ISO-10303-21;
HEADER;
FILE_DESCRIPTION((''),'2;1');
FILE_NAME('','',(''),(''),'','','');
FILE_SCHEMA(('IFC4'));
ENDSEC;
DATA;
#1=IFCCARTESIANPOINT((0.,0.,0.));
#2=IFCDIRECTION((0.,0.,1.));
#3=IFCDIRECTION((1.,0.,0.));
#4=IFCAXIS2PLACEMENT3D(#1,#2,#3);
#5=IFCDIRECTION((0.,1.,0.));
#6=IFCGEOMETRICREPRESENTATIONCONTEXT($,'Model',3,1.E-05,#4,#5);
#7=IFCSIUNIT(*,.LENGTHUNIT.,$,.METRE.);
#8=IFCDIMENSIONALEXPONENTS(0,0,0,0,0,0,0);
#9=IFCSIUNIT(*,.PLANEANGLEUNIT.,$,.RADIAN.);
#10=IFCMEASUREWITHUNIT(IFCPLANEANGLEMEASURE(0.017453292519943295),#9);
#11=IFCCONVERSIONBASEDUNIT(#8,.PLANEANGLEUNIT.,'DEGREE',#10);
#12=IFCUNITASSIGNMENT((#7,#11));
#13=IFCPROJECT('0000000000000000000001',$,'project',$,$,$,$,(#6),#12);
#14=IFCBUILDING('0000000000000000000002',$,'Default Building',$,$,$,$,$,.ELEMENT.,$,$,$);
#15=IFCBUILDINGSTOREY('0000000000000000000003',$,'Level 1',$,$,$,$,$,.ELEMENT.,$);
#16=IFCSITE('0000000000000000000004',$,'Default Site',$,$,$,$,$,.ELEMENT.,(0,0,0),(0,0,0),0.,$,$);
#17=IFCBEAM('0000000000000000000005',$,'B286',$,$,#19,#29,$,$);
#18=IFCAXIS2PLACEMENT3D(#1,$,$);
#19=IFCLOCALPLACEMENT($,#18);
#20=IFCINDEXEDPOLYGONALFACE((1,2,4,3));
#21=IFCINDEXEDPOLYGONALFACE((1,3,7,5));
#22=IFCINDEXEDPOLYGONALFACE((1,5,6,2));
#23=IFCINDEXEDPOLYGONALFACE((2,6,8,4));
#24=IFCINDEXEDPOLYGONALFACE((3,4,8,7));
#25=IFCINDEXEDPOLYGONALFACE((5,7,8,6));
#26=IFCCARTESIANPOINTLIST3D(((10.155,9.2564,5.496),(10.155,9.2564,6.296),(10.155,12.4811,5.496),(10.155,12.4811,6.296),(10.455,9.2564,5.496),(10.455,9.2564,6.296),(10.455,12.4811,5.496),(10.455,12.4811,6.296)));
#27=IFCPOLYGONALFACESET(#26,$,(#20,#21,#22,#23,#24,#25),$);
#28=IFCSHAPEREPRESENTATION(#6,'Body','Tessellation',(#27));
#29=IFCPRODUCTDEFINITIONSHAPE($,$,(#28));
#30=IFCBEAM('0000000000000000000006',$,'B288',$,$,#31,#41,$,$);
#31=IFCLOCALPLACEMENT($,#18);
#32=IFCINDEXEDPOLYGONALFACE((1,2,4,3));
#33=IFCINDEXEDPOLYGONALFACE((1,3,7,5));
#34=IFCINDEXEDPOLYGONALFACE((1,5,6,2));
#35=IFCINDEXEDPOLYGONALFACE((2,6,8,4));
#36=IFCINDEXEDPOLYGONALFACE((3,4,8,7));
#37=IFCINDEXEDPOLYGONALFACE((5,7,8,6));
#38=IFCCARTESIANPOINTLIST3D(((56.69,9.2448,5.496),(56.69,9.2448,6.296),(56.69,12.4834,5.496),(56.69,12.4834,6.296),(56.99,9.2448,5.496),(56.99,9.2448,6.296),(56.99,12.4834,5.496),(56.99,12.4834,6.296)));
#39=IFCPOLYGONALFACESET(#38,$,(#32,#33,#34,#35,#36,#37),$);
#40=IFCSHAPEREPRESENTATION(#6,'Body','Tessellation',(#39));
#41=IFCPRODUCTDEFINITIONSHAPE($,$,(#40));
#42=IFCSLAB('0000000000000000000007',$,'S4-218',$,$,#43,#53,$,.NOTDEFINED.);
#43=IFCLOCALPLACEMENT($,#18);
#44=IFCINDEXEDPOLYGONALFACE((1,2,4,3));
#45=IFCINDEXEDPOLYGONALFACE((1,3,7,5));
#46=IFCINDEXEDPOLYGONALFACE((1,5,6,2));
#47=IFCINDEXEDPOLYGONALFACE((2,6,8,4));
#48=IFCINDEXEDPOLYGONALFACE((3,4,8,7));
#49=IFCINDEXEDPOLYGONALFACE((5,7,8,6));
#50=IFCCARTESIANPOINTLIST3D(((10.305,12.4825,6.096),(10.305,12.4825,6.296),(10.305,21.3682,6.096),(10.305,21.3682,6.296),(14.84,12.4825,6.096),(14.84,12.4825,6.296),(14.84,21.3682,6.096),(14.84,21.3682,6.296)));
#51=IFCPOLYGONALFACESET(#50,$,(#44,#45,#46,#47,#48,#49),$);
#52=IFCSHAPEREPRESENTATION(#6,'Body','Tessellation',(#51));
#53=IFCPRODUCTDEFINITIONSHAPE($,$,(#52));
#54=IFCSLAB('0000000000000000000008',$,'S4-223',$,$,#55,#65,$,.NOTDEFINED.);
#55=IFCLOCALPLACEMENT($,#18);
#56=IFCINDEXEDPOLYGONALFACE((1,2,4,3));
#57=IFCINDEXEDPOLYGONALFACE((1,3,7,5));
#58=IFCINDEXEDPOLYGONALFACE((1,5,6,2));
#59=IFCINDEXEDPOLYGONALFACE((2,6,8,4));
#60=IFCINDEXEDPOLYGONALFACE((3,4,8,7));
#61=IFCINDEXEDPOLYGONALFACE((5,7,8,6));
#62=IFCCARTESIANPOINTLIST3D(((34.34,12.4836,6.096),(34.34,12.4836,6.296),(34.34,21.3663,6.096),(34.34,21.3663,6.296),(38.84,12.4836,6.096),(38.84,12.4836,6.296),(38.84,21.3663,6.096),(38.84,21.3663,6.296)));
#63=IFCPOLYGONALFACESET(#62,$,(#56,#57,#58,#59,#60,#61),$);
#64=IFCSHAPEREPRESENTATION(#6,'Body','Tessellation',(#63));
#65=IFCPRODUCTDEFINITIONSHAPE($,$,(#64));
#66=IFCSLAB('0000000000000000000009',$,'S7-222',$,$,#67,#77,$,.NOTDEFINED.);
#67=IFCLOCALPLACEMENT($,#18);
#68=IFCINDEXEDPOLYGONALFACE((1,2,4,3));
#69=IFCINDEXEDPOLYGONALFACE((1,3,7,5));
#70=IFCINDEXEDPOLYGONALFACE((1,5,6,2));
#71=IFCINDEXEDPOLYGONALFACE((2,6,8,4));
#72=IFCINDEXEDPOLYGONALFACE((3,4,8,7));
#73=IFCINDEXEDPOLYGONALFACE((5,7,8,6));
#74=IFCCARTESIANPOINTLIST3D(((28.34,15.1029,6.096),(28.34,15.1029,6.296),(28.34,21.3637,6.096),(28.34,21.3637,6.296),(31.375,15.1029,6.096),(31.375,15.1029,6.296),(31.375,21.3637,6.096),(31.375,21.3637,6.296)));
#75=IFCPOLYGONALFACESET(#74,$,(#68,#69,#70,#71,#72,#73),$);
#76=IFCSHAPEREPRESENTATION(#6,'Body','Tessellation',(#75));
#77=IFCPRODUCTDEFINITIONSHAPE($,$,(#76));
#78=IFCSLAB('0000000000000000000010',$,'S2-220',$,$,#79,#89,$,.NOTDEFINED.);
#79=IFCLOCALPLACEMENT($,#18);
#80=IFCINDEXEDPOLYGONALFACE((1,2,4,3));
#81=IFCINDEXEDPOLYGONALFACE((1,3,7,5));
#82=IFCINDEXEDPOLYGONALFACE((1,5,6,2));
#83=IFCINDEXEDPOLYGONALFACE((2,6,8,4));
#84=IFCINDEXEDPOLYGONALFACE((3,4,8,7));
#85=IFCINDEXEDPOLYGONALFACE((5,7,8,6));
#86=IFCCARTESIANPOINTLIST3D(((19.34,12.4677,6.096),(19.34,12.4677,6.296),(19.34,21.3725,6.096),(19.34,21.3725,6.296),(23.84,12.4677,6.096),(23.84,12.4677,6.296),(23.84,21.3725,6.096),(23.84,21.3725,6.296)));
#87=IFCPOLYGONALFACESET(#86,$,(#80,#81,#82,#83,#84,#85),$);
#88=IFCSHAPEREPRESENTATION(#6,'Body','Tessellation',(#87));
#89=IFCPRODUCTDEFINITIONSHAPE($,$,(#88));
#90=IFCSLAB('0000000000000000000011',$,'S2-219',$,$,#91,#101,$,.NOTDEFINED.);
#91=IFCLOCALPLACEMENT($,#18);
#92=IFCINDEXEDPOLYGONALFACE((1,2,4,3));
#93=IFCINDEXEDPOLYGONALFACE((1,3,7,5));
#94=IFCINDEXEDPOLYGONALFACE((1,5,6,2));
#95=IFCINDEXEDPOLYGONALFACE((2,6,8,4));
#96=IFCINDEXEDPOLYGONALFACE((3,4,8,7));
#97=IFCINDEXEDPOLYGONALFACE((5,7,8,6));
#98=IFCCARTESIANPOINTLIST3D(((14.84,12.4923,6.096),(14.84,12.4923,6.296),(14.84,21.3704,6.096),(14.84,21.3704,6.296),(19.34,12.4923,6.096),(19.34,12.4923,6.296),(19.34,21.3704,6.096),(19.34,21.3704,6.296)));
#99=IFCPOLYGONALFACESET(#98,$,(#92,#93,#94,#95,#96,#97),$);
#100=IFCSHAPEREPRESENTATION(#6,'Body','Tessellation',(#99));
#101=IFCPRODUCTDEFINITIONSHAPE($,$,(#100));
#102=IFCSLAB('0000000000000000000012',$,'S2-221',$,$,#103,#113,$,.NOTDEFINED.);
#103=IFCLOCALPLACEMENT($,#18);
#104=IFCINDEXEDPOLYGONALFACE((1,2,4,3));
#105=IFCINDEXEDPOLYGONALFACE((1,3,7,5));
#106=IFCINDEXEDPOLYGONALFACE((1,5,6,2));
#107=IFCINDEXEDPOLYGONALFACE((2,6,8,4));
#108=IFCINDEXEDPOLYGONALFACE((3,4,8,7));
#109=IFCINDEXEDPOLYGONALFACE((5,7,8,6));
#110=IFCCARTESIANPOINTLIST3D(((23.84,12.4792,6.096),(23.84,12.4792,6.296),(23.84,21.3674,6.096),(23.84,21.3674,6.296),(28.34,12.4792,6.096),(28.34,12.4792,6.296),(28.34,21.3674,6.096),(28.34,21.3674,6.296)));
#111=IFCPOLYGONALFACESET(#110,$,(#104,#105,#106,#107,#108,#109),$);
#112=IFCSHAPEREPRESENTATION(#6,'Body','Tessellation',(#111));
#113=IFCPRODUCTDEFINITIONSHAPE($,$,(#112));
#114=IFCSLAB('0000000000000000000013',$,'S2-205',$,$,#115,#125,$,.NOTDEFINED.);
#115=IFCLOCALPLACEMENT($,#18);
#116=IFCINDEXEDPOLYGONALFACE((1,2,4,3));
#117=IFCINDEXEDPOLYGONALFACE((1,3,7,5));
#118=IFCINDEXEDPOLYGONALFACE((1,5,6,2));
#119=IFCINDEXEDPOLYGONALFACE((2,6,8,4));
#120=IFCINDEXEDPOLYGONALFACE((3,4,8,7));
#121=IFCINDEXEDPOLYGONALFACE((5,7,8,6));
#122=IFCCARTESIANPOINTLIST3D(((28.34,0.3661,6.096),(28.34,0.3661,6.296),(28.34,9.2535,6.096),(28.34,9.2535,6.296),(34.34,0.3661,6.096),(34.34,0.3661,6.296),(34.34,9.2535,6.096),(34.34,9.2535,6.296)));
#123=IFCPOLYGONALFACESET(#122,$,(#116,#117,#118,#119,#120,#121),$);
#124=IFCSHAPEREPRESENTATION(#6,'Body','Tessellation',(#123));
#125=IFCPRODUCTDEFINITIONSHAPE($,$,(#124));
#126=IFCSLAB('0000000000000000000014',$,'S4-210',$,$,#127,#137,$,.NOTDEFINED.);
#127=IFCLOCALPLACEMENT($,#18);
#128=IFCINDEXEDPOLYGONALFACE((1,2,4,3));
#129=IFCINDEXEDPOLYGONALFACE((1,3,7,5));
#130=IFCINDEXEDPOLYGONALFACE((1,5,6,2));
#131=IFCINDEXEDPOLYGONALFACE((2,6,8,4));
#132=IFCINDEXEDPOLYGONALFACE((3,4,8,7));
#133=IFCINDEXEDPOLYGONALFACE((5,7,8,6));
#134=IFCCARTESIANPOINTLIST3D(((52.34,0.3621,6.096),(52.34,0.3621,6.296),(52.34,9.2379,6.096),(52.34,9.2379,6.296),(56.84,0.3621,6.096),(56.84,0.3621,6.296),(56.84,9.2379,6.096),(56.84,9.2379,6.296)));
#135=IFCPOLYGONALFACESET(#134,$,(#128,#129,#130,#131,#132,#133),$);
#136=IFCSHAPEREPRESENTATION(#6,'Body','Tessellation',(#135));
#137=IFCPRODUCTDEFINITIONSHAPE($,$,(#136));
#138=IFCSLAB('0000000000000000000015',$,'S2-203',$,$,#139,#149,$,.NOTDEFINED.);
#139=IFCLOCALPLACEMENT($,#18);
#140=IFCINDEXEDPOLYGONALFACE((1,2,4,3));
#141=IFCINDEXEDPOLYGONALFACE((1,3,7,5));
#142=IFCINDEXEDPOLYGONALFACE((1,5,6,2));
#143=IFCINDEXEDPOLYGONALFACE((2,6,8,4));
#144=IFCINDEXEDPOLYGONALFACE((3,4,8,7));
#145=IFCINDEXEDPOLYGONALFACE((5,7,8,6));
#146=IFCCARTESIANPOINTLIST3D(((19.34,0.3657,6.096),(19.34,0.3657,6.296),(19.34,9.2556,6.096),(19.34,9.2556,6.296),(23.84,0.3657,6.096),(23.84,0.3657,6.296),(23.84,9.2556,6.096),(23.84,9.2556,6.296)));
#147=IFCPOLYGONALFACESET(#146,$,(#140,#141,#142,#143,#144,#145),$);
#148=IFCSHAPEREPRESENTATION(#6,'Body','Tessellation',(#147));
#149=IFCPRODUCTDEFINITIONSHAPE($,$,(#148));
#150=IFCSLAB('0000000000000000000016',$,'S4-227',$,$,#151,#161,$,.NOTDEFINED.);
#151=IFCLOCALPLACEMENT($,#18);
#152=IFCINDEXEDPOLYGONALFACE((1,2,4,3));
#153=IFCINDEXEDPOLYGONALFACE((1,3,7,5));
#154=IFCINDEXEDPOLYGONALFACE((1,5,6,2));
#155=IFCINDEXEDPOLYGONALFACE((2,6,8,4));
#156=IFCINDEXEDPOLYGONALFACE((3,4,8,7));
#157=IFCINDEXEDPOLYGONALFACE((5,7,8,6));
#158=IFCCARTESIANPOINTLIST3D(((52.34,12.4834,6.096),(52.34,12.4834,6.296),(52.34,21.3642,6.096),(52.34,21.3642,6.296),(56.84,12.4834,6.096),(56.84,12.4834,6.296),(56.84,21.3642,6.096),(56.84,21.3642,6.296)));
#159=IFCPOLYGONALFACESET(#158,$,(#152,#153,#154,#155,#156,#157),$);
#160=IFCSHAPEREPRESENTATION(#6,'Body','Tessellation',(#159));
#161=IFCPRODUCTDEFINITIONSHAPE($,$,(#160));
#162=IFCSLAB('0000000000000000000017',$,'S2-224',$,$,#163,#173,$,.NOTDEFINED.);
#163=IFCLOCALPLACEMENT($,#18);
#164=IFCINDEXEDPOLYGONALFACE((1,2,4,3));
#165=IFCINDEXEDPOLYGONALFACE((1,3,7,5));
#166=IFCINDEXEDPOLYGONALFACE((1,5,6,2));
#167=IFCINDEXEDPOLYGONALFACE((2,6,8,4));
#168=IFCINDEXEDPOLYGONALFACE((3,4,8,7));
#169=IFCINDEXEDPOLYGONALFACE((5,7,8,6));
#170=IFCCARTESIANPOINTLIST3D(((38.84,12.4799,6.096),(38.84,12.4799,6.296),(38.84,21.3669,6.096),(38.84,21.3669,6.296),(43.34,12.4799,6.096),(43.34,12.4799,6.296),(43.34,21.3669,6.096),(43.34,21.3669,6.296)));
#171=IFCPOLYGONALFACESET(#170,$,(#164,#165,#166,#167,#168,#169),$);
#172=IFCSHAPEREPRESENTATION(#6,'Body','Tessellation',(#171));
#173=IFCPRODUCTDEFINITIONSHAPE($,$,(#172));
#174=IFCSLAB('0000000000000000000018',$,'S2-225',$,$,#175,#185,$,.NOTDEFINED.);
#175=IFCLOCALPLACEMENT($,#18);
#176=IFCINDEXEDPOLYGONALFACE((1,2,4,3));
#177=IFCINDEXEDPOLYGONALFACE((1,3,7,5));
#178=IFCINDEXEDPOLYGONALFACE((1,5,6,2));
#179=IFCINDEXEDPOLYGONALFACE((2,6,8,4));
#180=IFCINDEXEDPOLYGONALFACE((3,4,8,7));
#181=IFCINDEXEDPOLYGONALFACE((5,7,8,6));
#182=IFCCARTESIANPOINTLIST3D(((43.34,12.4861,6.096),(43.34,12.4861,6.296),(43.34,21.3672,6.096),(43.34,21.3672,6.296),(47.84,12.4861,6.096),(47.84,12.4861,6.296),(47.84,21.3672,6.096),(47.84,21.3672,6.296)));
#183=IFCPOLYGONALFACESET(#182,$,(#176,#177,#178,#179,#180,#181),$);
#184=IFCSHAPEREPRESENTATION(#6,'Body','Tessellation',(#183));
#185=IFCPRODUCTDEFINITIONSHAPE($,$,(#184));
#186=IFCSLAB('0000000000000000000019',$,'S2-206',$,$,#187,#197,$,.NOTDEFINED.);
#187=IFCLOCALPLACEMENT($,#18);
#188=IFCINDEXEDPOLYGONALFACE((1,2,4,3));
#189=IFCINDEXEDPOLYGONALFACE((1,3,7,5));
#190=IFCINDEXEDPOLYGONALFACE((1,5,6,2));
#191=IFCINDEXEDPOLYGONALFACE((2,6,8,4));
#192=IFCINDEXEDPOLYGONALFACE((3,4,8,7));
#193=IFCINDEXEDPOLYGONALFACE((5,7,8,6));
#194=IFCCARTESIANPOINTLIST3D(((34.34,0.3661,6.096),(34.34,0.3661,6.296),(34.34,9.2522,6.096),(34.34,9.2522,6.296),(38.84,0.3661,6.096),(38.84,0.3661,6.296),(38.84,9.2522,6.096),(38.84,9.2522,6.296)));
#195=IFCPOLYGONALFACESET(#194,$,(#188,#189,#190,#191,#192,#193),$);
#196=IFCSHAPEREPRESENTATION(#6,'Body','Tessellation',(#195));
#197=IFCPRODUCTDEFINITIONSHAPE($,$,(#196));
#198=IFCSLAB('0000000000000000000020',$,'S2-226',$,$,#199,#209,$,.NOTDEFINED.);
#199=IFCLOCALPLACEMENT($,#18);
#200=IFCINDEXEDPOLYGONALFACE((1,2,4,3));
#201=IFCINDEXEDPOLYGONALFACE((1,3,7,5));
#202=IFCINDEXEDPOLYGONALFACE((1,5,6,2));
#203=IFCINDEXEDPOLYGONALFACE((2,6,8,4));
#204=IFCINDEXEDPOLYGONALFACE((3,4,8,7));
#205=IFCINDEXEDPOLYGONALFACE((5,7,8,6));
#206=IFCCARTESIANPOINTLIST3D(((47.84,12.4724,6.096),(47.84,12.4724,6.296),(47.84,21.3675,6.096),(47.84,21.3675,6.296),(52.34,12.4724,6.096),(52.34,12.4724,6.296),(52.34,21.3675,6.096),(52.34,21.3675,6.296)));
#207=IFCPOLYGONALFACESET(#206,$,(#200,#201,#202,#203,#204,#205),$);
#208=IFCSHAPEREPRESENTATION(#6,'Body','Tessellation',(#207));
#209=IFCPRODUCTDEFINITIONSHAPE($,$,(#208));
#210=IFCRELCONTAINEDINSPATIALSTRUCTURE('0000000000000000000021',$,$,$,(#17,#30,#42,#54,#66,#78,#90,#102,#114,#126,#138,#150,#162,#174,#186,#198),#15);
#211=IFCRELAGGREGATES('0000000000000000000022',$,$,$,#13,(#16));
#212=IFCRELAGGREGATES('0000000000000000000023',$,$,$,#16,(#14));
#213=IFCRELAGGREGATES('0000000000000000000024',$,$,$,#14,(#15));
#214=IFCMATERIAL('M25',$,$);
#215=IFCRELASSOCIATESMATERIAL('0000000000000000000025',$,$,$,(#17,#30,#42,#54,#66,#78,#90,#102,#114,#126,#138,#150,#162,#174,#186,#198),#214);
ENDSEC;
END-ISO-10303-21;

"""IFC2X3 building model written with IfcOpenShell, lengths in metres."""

from ifc_helpers import new_model, entity, si_unit, converted_unit, direction, frame, frame_2d, origin_with_axes, place, context, project, spatial, rectangle, extrude, material, element, save


model = new_model("IFC2X3")

# Units and contexts
model_context = context("Model", 3, precision=1e-05, world=origin_with_axes(), true_north=direction((0.0, 1.0, 0.0)))
ifc_project = project(units=[si_unit("LENGTHUNIT", "METRE"), converted_unit("PLANEANGLEUNIT", "DEGREE", entity("IfcPlaneAngleMeasure", 0.017453292519943295), si_unit("PLANEANGLEUNIT", "RADIAN"), dimensions=[0, 0, 0, 0, 0, 0, 0])], contexts=[model_context])

# Site, building, storey
site = spatial("IfcSite", under=ifc_project, Name="Default Site", CompositionType="ELEMENT", RefLatitude=(0, 0, 0), RefLongitude=(0, 0, 0), RefElevation=0.0)
building = spatial("IfcBuilding", under=site, Name="Default Building", CompositionType="ELEMENT")
storey = spatial("IfcBuildingStorey", under=building, Name="Level 1", CompositionType="ELEMENT")

# Beams
ifc_material = material(Name="M25")
placement = place(None, origin_with_axes())
element("IfcBeam", 1, at=placement, inside=storey, material=ifc_material, Name="B286", context=model_context, shape_type="SweptSolid", body=[
    extrude(rectangle(XDim=0.3, YDim=0.8, at=frame_2d((0.0, 0.0), x_axis=(0.0, 1.0, 0.0))), frame((10.305, 12.4811, 5.896), z_axis=(0.0, -1.0, 0.0), x_axis=(0.0, 0.0, -1.0)), (0.0, 0.0, 1.0), 3.2247),
])
element("IfcBeam", 2, at=placement, inside=storey, material=ifc_material, Name="B288", context=model_context, shape_type="SweptSolid", body=[
    extrude(rectangle(XDim=0.3, YDim=0.8, at=frame_2d((0.0, 0.0), x_axis=(0.0, 1.0, 0.0))), frame((56.84, 12.4834, 5.896), z_axis=(0.0, -1.0, 0.0), x_axis=(0.0, 0.0, -1.0)), (0.0, 0.0, 1.0), 3.2386),
])

# Slabs
element("IfcSlab", 3, at=placement, inside=storey, material=ifc_material, Name="S4-218", PredefinedType="NOTDEFINED", context=model_context, shape_type="SweptSolid", body=[
    extrude(rectangle(XDim=4.535, YDim=8.8857, at=frame_2d((0.0, 0.0), x_axis=(1.0, 0.0, 0.0))), frame((12.5725, 16.9253, 6.096), z_axis=(0.0, 0.0, 1.0), x_axis=(1.0, 0.0, 0.0)), (0.0, 0.0, 1.0), 0.2),
])
element("IfcSlab", 4, at=placement, inside=storey, material=ifc_material, Name="S4-223", PredefinedType="NOTDEFINED", context=model_context, shape_type="SweptSolid", body=[
    extrude(rectangle(XDim=4.5, YDim=8.8827, at=frame_2d((0.0, 0.0), x_axis=(1.0, 0.0, 0.0))), frame((36.59, 16.925, 6.096), z_axis=(0.0, 0.0, 1.0), x_axis=(1.0, 0.0, 0.0)), (0.0, 0.0, 1.0), 0.2),
])
element("IfcSlab", 5, at=placement, inside=storey, material=ifc_material, Name="S7-222", PredefinedType="NOTDEFINED", context=model_context, shape_type="SweptSolid", body=[
    extrude(rectangle(XDim=3.035, YDim=6.2608, at=frame_2d((0.0, 0.0), x_axis=(1.0, 0.0, 0.0))), frame((29.8575, 18.2333, 6.096), z_axis=(0.0, 0.0, 1.0), x_axis=(1.0, 0.0, 0.0)), (0.0, 0.0, 1.0), 0.2),
])
element("IfcSlab", 6, at=placement, inside=storey, material=ifc_material, Name="S2-220", PredefinedType="NOTDEFINED", context=model_context, shape_type="SweptSolid", body=[
    extrude(rectangle(XDim=4.5, YDim=8.9048, at=frame_2d((0.0, 0.0), x_axis=(1.0, 0.0, 0.0))), frame((21.59, 16.9201, 6.096), z_axis=(0.0, 0.0, 1.0), x_axis=(1.0, 0.0, 0.0)), (0.0, 0.0, 1.0), 0.2),
])
element("IfcSlab", 7, at=placement, inside=storey, material=ifc_material, Name="S2-219", PredefinedType="NOTDEFINED", context=model_context, shape_type="SweptSolid", body=[
    extrude(rectangle(XDim=4.5, YDim=8.8781, at=frame_2d((0.0, 0.0), x_axis=(1.0, 0.0, 0.0))), frame((17.09, 16.9313, 6.096), z_axis=(0.0, 0.0, 1.0), x_axis=(1.0, 0.0, 0.0)), (0.0, 0.0, 1.0), 0.2),
])
element("IfcSlab", 8, at=placement, inside=storey, material=ifc_material, Name="S2-221", PredefinedType="NOTDEFINED", context=model_context, shape_type="SweptSolid", body=[
    extrude(rectangle(XDim=4.5, YDim=8.8882, at=frame_2d((0.0, 0.0), x_axis=(1.0, 0.0, 0.0))), frame((26.09, 16.9233, 6.096), z_axis=(0.0, 0.0, 1.0), x_axis=(1.0, 0.0, 0.0)), (0.0, 0.0, 1.0), 0.2),
])
element("IfcSlab", 9, at=placement, inside=storey, material=ifc_material, Name="S2-205", PredefinedType="NOTDEFINED", context=model_context, shape_type="SweptSolid", body=[
    extrude(rectangle(XDim=6.0, YDim=8.8874, at=frame_2d((0.0, 0.0), x_axis=(1.0, 0.0, 0.0))), frame((31.34, 4.8098, 6.096), z_axis=(0.0, 0.0, 1.0), x_axis=(1.0, 0.0, 0.0)), (0.0, 0.0, 1.0), 0.2),
])
element("IfcSlab", 10, at=placement, inside=storey, material=ifc_material, Name="S4-210", PredefinedType="NOTDEFINED", context=model_context, shape_type="SweptSolid", body=[
    extrude(rectangle(XDim=4.5, YDim=8.8758, at=frame_2d((0.0, 0.0), x_axis=(1.0, 0.0, 0.0))), frame((54.59, 4.8, 6.096), z_axis=(0.0, 0.0, 1.0), x_axis=(1.0, 0.0, 0.0)), (0.0, 0.0, 1.0), 0.2),
])
element("IfcSlab", 11, at=placement, inside=storey, material=ifc_material, Name="S2-203", PredefinedType="NOTDEFINED", context=model_context, shape_type="SweptSolid", body=[
    extrude(rectangle(XDim=4.5, YDim=8.89, at=frame_2d((0.0, 0.0), x_axis=(1.0, 0.0, 0.0))), frame((21.59, 4.8106, 6.096), z_axis=(0.0, 0.0, 1.0), x_axis=(1.0, 0.0, 0.0)), (0.0, 0.0, 1.0), 0.2),
])
element("IfcSlab", 12, at=placement, inside=storey, material=ifc_material, Name="S4-227", PredefinedType="NOTDEFINED", context=model_context, shape_type="SweptSolid", body=[
    extrude(rectangle(XDim=4.5, YDim=8.8807, at=frame_2d((0.0, 0.0), x_axis=(1.0, 0.0, 0.0))), frame((54.59, 16.9238, 6.096), z_axis=(0.0, 0.0, 1.0), x_axis=(1.0, 0.0, 0.0)), (0.0, 0.0, 1.0), 0.2),
])
element("IfcSlab", 13, at=placement, inside=storey, material=ifc_material, Name="S2-224", PredefinedType="NOTDEFINED", context=model_context, shape_type="SweptSolid", body=[
    extrude(rectangle(XDim=4.5, YDim=8.8871, at=frame_2d((0.0, 0.0), x_axis=(1.0, 0.0, 0.0))), frame((41.09, 16.9234, 6.096), z_axis=(0.0, 0.0, 1.0), x_axis=(1.0, 0.0, 0.0)), (0.0, 0.0, 1.0), 0.2),
])
element("IfcSlab", 14, at=placement, inside=storey, material=ifc_material, Name="S2-225", PredefinedType="NOTDEFINED", context=model_context, shape_type="SweptSolid", body=[
    extrude(rectangle(XDim=4.5, YDim=8.8811, at=frame_2d((0.0, 0.0), x_axis=(1.0, 0.0, 0.0))), frame((45.59, 16.9266, 6.096), z_axis=(0.0, 0.0, 1.0), x_axis=(1.0, 0.0, 0.0)), (0.0, 0.0, 1.0), 0.2),
])
element("IfcSlab", 15, at=placement, inside=storey, material=ifc_material, Name="S2-206", PredefinedType="NOTDEFINED", context=model_context, shape_type="SweptSolid", body=[
    extrude(rectangle(XDim=4.5, YDim=8.8861, at=frame_2d((0.0, 0.0), x_axis=(1.0, 0.0, 0.0))), frame((36.59, 4.8092, 6.096), z_axis=(0.0, 0.0, 1.0), x_axis=(1.0, 0.0, 0.0)), (0.0, 0.0, 1.0), 0.2),
])
element("IfcSlab", 16, at=placement, inside=storey, material=ifc_material, Name="S2-226", PredefinedType="NOTDEFINED", context=model_context, shape_type="SweptSolid", body=[
    extrude(rectangle(XDim=4.5, YDim=8.8951, at=frame_2d((0.0, 0.0), x_axis=(1.0, 0.0, 0.0))), frame((50.09, 16.9199, 6.096), z_axis=(0.0, 0.0, 1.0), x_axis=(1.0, 0.0, 0.0)), (0.0, 0.0, 1.0), 0.2),
])

save(model, "model.ifc")
